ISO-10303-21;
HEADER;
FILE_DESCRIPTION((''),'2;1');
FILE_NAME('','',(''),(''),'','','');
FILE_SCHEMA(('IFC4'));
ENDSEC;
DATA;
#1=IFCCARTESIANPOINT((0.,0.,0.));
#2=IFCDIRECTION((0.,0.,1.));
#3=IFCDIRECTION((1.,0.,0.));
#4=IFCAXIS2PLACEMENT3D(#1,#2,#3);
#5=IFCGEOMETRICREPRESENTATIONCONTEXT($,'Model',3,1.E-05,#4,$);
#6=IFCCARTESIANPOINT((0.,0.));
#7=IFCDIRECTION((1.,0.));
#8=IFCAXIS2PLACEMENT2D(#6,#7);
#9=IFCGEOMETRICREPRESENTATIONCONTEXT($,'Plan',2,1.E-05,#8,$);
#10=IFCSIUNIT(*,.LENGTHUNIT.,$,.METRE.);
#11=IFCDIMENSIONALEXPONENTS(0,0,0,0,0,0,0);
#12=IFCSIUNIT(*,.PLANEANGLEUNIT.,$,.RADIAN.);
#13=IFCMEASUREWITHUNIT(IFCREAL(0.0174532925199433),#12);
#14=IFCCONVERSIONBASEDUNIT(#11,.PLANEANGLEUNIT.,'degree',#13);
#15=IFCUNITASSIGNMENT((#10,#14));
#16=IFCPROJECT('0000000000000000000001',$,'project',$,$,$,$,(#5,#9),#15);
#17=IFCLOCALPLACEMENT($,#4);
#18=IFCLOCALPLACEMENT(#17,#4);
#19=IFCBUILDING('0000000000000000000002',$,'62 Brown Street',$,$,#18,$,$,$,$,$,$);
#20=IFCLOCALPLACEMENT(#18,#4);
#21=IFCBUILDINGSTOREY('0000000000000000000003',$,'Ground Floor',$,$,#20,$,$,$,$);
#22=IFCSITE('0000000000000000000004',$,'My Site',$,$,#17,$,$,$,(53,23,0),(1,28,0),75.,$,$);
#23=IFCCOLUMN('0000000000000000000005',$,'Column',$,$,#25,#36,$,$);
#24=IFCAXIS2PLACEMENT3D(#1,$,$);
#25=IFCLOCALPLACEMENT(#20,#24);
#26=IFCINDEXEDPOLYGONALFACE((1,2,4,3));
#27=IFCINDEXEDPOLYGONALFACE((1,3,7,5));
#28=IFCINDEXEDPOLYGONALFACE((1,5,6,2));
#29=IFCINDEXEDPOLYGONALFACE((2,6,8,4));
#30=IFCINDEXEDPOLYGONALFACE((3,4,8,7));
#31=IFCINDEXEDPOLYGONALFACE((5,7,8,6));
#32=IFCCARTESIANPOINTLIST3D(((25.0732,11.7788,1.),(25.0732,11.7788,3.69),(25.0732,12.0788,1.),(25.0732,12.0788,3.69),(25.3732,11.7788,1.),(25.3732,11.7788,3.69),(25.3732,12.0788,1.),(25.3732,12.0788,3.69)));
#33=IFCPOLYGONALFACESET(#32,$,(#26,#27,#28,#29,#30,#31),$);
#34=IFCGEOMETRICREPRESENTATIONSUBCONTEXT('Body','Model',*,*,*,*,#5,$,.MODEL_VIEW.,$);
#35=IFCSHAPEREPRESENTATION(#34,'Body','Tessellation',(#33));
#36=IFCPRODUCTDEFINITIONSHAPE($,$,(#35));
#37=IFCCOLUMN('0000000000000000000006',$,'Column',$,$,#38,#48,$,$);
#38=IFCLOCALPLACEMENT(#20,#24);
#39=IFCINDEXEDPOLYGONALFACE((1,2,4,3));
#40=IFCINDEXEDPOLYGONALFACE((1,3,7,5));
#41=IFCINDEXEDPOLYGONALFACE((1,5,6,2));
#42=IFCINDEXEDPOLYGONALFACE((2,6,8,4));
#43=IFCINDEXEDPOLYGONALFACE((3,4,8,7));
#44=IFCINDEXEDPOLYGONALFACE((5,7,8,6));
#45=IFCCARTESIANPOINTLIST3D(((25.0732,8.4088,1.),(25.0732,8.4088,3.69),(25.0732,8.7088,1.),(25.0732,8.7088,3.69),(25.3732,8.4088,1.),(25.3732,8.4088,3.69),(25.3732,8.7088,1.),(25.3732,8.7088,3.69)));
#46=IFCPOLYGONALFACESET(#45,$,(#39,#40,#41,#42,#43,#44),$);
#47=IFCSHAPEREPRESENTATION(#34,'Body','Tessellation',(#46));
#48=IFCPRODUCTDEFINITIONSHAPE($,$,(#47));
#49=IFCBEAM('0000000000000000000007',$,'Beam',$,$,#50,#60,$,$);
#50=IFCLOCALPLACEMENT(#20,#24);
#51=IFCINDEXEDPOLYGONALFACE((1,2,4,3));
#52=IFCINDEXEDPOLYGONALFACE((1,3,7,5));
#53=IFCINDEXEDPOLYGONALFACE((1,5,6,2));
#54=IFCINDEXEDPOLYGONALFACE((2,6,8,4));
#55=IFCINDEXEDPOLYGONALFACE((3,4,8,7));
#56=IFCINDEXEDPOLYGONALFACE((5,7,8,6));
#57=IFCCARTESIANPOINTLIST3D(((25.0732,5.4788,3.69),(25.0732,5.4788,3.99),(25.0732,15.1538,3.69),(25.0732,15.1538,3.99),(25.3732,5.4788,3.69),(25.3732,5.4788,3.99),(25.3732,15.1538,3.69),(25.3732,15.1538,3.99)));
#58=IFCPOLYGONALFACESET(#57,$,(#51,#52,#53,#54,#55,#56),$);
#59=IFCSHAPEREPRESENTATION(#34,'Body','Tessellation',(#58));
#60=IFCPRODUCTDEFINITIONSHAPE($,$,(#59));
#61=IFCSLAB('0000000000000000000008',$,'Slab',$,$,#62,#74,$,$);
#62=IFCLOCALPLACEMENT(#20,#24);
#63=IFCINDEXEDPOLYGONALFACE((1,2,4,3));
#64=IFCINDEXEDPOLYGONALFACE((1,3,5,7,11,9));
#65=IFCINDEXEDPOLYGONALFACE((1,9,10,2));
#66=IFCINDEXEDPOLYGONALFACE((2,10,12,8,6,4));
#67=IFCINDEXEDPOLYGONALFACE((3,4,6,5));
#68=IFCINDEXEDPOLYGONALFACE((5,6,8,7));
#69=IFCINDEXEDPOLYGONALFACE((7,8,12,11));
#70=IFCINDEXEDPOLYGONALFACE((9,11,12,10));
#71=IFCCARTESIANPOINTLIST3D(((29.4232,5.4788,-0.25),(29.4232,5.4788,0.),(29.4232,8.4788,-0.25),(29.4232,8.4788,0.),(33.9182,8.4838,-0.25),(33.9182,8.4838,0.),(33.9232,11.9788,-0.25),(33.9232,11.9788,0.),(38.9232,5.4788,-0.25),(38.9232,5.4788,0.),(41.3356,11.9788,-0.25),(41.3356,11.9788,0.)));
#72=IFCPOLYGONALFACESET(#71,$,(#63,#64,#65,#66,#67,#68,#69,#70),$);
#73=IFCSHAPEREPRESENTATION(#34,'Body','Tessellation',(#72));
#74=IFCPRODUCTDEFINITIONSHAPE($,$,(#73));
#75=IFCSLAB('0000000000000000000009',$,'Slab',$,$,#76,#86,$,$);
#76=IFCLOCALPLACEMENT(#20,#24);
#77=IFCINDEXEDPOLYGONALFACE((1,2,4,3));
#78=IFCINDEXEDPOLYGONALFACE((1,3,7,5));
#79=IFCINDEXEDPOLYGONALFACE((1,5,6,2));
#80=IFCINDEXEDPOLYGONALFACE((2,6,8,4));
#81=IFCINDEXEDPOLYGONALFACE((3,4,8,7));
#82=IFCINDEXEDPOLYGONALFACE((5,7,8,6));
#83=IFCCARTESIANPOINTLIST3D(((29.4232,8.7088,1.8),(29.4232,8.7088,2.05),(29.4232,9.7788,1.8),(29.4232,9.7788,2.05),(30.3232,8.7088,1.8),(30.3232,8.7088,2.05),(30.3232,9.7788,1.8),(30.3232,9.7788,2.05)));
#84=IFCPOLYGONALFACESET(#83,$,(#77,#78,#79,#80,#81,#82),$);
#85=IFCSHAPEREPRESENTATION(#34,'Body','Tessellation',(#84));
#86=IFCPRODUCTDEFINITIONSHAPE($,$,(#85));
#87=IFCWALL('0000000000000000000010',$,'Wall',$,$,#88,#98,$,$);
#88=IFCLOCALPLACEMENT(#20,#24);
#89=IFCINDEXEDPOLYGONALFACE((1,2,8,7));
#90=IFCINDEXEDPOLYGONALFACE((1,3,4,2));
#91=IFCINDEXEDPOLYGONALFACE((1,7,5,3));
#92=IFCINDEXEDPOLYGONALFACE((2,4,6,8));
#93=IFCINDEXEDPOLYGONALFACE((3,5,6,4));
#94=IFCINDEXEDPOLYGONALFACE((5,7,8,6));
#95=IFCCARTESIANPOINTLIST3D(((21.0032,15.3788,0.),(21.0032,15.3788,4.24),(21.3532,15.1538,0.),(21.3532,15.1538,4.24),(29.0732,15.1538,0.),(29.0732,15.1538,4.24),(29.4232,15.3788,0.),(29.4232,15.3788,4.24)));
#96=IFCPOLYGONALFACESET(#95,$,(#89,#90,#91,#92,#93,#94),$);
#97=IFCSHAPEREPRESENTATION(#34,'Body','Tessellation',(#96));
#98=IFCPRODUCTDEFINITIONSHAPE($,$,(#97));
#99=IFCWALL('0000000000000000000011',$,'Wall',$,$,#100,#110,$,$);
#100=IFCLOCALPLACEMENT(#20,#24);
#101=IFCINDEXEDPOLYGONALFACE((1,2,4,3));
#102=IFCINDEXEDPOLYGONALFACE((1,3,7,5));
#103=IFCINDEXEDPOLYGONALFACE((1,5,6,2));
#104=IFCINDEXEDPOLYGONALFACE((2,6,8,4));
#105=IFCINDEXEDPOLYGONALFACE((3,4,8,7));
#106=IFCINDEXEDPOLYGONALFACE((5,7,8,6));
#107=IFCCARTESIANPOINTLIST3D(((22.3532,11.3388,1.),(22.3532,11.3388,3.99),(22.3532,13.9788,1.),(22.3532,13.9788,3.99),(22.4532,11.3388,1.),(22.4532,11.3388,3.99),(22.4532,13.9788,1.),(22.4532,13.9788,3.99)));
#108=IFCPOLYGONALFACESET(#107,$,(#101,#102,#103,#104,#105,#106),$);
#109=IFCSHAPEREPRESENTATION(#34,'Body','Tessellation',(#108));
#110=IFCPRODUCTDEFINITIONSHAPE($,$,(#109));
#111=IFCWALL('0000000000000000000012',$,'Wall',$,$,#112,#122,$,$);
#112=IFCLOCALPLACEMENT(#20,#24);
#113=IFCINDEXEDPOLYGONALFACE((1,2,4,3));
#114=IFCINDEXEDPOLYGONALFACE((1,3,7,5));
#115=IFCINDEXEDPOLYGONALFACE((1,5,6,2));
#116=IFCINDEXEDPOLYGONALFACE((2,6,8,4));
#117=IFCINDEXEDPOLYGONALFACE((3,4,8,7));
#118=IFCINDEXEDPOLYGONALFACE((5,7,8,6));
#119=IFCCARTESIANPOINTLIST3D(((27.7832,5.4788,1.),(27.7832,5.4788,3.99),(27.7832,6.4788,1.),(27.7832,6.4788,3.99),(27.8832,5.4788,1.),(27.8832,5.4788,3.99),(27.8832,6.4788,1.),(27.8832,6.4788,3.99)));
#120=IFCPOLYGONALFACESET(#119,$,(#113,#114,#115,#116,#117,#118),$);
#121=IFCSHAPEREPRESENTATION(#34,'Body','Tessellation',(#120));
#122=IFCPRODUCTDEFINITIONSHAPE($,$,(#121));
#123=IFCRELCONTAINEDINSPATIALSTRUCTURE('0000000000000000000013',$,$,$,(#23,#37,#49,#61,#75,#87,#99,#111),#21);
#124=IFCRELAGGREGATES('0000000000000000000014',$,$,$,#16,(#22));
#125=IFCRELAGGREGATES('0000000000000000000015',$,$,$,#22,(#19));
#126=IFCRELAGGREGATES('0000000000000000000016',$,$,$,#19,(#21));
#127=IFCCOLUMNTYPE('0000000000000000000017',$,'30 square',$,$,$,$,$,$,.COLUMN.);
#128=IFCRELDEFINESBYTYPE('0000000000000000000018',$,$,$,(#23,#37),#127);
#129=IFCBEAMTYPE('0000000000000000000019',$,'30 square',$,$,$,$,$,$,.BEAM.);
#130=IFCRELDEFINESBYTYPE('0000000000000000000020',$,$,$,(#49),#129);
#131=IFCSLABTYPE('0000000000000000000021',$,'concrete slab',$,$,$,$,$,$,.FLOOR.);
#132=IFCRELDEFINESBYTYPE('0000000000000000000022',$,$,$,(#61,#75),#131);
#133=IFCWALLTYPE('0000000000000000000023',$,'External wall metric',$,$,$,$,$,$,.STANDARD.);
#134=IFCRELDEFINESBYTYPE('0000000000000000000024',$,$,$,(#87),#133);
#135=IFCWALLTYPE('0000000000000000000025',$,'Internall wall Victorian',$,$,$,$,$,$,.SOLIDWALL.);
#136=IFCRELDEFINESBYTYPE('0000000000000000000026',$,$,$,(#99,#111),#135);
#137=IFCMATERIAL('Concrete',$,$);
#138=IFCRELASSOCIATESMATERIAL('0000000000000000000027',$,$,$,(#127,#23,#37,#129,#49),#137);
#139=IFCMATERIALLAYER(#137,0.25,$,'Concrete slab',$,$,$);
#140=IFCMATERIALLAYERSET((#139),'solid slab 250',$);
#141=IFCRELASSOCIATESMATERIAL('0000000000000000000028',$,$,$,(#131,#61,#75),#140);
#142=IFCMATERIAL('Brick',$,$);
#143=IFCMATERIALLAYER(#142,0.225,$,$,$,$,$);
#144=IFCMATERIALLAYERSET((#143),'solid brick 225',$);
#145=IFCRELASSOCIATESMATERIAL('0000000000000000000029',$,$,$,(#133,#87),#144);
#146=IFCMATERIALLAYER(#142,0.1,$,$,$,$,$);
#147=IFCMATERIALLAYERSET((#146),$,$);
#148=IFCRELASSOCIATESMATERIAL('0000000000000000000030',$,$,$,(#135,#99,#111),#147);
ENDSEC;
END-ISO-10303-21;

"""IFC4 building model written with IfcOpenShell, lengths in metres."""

from ifc_helpers import new_model, entity, si_unit, converted_unit, frame, origin_with_axes, origin_2d_with_axis, place, context, subcontext, project, spatial, line, indexed_curve, rectangle, outline, extrude, clip, halfspace, material, layer, layer_set, layer_usage, material_profile, profile_set, profile_usage, type_object, element, save


model = new_model("IFC4")

# Units and contexts
model_context = context("Model", 3, precision=1e-05, world=origin_with_axes())
plan_context = context("Plan", 2, precision=1e-05, world=origin_2d_with_axis())
body_context_1 = subcontext(model_context, "Body", "Model", "MODEL_VIEW")
ifc_project = project(units=[si_unit("LENGTHUNIT", "METRE"), converted_unit("PLANEANGLEUNIT", "degree", entity("IfcReal", 0.0174532925199433), si_unit("PLANEANGLEUNIT", "RADIAN"), dimensions=[0, 0, 0, 0, 0, 0, 0])], contexts=[model_context, plan_context])

# Site, building, storey
site_placement = place(None, origin_with_axes())
site = spatial("IfcSite", under=ifc_project, at=site_placement, Name="My Site", RefLatitude=(53, 23, 0), RefLongitude=(1, 28, 0), RefElevation=75.0)
building_placement = place(site_placement, origin_with_axes())
building = spatial("IfcBuilding", under=site, at=building_placement, Name="62 Brown Street")
storey_placement = place(building_placement, origin_with_axes())
storey = spatial("IfcBuildingStorey", under=building, at=storey_placement, Name="Ground Floor")

# Columns
ifc_material_1 = material(Name="Concrete")
ifc_material_profile_1 = material_profile(ifc_material_1, rectangle(XDim=0.3, YDim=0.3))
ifc_profile_set_1 = profile_set([ifc_material_profile_1])
ifc_profile_usage_1 = profile_usage(ifc_profile_set_1, cardinal=5)
column_type = type_object("IfcColumnType", Name="30 square", PredefinedType="COLUMN", material=ifc_profile_set_1)
column_1_placement = place(storey_placement, frame((25.2232, 11.9288, 1.0), z_axis=(0.0, 0.0, 1.0), x_axis=(1.0, 0.0, 0.0)))
element("IfcColumn", 1, at=column_1_placement, inside=storey, type_object=column_type, material=ifc_profile_usage_1, Name="Column", context=body_context_1, shape_type="SweptSolid", body=[
    extrude(rectangle(XDim=0.3, YDim=0.3), origin_with_axes(), (0.0, 0.0, 1.0), 2.69),
])
ifc_profile_usage_2 = profile_usage(ifc_profile_set_1, cardinal=5)
column_2_placement = place(storey_placement, frame((25.2232, 8.5588, 1.0), z_axis=(0.0, 0.0, 1.0), x_axis=(1.0, 0.0, 0.0)))
element("IfcColumn", 2, at=column_2_placement, inside=storey, type_object=column_type, material=ifc_profile_usage_2, Name="Column", context=body_context_1, shape_type="SweptSolid", body=[
    extrude(rectangle(XDim=0.3, YDim=0.3), origin_with_axes(), (0.0, 0.0, 1.0), 2.69),
])

# Beam
ifc_material_profile_2 = material_profile(ifc_material_1, rectangle(XDim=0.3, YDim=0.3))
ifc_profile_set_2 = profile_set([ifc_material_profile_2])
ifc_profile_usage_3 = profile_usage(ifc_profile_set_2, cardinal=5)
beam_type = type_object("IfcBeamType", Name="30 square", PredefinedType="BEAM", material=ifc_profile_set_2)
beam_placement = place(storey_placement, frame((25.2232, 5.4788, 3.84), z_axis=(0.0, 1.0, 0.0), x_axis=(-1.0, 0.0, 0.0)))
element("IfcBeam", 3, at=beam_placement, inside=storey, type_object=beam_type, material=ifc_profile_usage_3, Name="Beam", context=body_context_1, shape_type="SweptSolid", body=[
    extrude(rectangle(XDim=0.3, YDim=0.3), origin_with_axes(), (0.0, 0.0, 1.0), 9.675),
])

# Slabs
ifc_layer_1 = layer(ifc_material_1, 0.25, Name="Concrete slab")
ifc_layer_set_1 = layer_set([ifc_layer_1], Name="solid slab 250")
ifc_layer_usage_1 = layer_usage(ifc_layer_set_1, "AXIS3", "POSITIVE", 0.0)
slab_type = type_object("IfcSlabType", Name="concrete slab", PredefinedType="FLOOR", material=ifc_layer_set_1)
slab_1_placement = place(storey_placement, frame((29.4232, 5.4788, -0.25), z_axis=(0.0, 0.0, 1.0), x_axis=(1.0, 0.0, 0.0)))
element("IfcSlab", 4, at=slab_1_placement, inside=storey, type_object=slab_type, material=ifc_layer_usage_1, Name="Slab", context=body_context_1, shape_type="SweptSolid", body=[
    extrude(outline(indexed_curve([(0.0, 0.0), (9.5, 0.0), (11.9124, 6.5), (0.0, 3.0), (4.5, 6.5), (4.495, 3.005)], segments=[line(1, 2), line(2, 3), line(3, 5), line(5, 6), line(6, 4), line(4, 1)], self_intersect=False)), None, (0.0, 0.0, 1.0), 0.25),
])
ifc_layer_usage_2 = layer_usage(ifc_layer_set_1, "AXIS3", "POSITIVE", 0.0)
slab_2_placement = place(storey_placement, frame((29.4232, 8.7088, 1.8), z_axis=(0.0, 0.0, 1.0), x_axis=(1.0, 0.0, 0.0)))
element("IfcSlab", 5, at=slab_2_placement, inside=storey, type_object=slab_type, material=ifc_layer_usage_2, Name="Slab", context=body_context_1, shape_type="SweptSolid", body=[
    extrude(outline(indexed_curve([(0.9, 1.07), (0.9, 0.0), (0.0, 0.0), (0.0, 1.07)], segments=[line(3, 2), line(2, 1), line(1, 4), line(4, 3)], self_intersect=False)), None, (0.0, 0.0, 1.0), 0.25),
])

# Walls
ifc_material_2 = material(Name="Brick")
ifc_layer_2 = layer(ifc_material_2, 0.225)
ifc_layer_set_2 = layer_set([ifc_layer_2], Name="solid brick 225")
wall_type_1 = type_object("IfcWallType", Name="External wall metric", PredefinedType="STANDARD", material=ifc_layer_set_2)
ifc_layer_usage_3 = layer_usage(ifc_layer_set_2, "AXIS2", "POSITIVE", 0.0)
wall_1_placement = place(storey_placement, frame((29.4232, 15.3788, 0.0), z_axis=(0.0, 0.0, 1.0), x_axis=(-1.0, 0.0, 0.0)))
element("IfcWall", 6, at=wall_1_placement, inside=storey, type_object=wall_type_1, material=ifc_layer_usage_3, Name="Wall", context=body_context_1, shape_type="Clipping", body=[
    clip(clip(extrude(outline(indexed_curve([(0.0, 0.0), (0.0, 0.225), (8.42, 0.225), (8.42, 0.0), (0.0, 0.0)], self_intersect=False)), origin_with_axes(), (0.0, 0.0, 1.0), 4.24), halfspace(frame((8.42, 0.0, 0.0), z_axis=(0.540756, 0.841179, 0.0), x_axis=(-0.841179, 0.540756, 0.0)), False)), halfspace(frame((0.0, 0.0, 0.0), z_axis=(-0.540758, 0.841178, 0.0), x_axis=(0.841178, 0.540758, 0.0)), False)),
])
ifc_layer_3 = layer(ifc_material_2, 0.1)
ifc_layer_set_3 = layer_set([ifc_layer_3])
ifc_layer_usage_4 = layer_usage(ifc_layer_set_3, "AXIS2", "POSITIVE", 0.0)
wall_type_2 = type_object("IfcWallType", Name="Internall wall Victorian", PredefinedType="SOLIDWALL", material=ifc_layer_set_3)
wall_2_placement = place(storey_placement, frame((22.4532, 11.3388, 1.0), z_axis=(0.0, 0.0, 1.0), x_axis=(0.0, 1.0, 0.0)))
element("IfcWall", 7, at=wall_2_placement, inside=storey, type_object=wall_type_2, material=ifc_layer_usage_4, Name="Wall", context=body_context_1, shape_type="SweptSolid", body=[
    extrude(outline(indexed_curve([(0.0, 0.0), (0.0, 0.1), (2.64, 0.1), (2.64, 0.0), (0.0, 0.0)], self_intersect=False)), origin_with_axes(), (0.0, 0.0, 1.0), 2.99),
])
ifc_layer_usage_5 = layer_usage(ifc_layer_set_3, "AXIS2", "POSITIVE", 0.0)
wall_3_placement = place(storey_placement, frame((27.8832, 5.4788, 1.0), z_axis=(0.0, 0.0, 1.0), x_axis=(0.0, 1.0, 0.0)))
element("IfcWall", 8, at=wall_3_placement, inside=storey, type_object=wall_type_2, material=ifc_layer_usage_5, Name="Wall", context=body_context_1, shape_type="SweptSolid", body=[
    extrude(outline(indexed_curve([(0.0, 0.0), (0.0, 0.1), (1.0, 0.1), (1.0, 0.0), (0.0, 0.0)], self_intersect=False)), origin_with_axes(), (0.0, 0.0, 1.0), 2.99),
])

save(model, "model.ifc")
